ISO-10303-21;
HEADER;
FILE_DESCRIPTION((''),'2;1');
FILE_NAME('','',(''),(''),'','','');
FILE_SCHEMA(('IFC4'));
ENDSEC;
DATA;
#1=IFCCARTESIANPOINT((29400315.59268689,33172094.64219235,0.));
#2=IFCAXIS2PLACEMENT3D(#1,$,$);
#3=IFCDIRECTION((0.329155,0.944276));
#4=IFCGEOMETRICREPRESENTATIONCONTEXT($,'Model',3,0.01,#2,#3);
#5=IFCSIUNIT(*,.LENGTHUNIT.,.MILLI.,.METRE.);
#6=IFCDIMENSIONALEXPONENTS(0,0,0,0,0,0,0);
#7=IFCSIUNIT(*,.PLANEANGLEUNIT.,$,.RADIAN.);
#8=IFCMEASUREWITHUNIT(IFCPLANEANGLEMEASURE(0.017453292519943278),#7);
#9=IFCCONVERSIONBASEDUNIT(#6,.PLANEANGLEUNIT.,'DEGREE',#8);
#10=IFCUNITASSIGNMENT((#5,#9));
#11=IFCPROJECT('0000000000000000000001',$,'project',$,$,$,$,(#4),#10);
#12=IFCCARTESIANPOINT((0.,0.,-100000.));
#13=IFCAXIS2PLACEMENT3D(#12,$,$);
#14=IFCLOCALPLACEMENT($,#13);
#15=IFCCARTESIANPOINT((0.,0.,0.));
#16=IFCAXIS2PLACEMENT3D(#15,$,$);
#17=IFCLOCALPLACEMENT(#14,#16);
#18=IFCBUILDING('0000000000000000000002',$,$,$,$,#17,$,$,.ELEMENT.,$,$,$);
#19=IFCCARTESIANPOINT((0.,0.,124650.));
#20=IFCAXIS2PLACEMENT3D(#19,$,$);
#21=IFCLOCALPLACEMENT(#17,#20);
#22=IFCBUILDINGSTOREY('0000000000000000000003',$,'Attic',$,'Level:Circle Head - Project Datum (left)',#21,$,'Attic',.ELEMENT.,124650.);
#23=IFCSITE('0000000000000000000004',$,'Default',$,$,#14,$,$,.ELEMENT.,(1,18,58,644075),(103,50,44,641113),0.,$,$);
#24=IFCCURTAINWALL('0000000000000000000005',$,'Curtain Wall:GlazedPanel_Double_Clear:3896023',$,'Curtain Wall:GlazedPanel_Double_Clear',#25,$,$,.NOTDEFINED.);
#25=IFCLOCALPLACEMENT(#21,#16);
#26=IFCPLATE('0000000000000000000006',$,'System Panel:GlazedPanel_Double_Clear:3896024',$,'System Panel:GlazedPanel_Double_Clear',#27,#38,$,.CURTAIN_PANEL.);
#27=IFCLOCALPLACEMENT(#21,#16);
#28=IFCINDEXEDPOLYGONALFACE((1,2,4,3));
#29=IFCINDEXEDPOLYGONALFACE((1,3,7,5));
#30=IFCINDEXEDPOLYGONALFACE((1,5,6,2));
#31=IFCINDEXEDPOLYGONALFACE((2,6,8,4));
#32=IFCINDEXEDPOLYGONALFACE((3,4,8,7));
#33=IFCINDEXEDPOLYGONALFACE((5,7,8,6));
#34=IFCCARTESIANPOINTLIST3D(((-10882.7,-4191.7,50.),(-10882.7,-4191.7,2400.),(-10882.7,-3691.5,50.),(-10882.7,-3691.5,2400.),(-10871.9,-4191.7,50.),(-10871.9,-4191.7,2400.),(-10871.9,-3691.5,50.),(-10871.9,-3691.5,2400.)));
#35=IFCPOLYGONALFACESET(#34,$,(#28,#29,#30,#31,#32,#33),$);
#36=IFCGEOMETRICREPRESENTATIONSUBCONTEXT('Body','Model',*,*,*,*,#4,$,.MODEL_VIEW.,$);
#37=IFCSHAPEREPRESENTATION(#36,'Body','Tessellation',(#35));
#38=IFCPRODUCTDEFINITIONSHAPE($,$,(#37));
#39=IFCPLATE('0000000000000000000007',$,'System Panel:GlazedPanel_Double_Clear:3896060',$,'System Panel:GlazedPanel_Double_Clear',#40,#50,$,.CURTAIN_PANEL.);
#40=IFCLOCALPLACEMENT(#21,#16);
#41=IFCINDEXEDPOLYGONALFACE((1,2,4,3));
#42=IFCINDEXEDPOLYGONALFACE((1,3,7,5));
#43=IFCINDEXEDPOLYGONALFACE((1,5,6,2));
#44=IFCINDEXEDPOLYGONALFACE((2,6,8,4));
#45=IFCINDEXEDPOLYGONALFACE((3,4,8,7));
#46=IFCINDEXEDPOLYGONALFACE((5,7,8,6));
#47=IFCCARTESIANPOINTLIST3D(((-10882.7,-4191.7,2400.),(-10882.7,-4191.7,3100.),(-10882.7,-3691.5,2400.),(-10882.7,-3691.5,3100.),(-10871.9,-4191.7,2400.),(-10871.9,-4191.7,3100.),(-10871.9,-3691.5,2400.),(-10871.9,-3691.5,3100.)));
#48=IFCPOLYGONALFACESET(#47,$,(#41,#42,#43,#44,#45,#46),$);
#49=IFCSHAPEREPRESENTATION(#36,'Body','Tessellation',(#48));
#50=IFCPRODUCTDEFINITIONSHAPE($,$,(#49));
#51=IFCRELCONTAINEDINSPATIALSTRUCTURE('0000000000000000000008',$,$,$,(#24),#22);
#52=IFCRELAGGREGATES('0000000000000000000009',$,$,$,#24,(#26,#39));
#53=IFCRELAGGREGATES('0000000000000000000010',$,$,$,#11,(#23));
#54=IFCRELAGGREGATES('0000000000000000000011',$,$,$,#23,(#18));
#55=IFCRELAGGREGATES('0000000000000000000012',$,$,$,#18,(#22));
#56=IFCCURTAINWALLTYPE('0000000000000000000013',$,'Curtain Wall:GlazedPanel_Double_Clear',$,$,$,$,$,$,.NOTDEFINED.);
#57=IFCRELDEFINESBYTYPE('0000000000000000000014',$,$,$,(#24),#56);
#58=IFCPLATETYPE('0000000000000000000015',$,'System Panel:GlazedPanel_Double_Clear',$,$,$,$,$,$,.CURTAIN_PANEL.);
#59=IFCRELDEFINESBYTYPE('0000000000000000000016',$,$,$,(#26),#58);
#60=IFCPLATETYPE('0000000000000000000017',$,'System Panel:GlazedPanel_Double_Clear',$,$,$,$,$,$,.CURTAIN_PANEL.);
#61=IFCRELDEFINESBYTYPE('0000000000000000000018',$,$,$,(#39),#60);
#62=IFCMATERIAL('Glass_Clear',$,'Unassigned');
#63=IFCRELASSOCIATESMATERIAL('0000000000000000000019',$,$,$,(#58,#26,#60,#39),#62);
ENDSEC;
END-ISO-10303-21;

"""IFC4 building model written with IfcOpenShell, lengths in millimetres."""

from ifc_helpers import new_model, entity, si_unit, converted_unit, direction, frame, origin, place, context, subcontext, project, spatial, indexed_curve, outline, extrude, source, transform, mapped, material, type_object, type_shapes, element, aggregate, save


model = new_model("IFC4")

# Units and contexts
model_context = context("Model", 3, precision=0.01, world=frame((29400315.59268689, 33172094.64219235, 0.0)), true_north=direction((0.329155, 0.944276)))
body_context = subcontext(model_context, "Body", "Model", "MODEL_VIEW")
ifc_project = project(units=[si_unit("LENGTHUNIT", "METRE", prefix="MILLI"), converted_unit("PLANEANGLEUNIT", "DEGREE", entity("IfcPlaneAngleMeasure", 0.017453292519943278), si_unit("PLANEANGLEUNIT", "RADIAN"), dimensions=[0, 0, 0, 0, 0, 0, 0])], contexts=[model_context])

# Site, building, storey
site_placement = place(None, frame((0.0, 0.0, -100000.0)))
site = spatial("IfcSite", under=ifc_project, at=site_placement, Name="Default", CompositionType="ELEMENT", RefLatitude=(1, 18, 58, 644075), RefLongitude=(103, 50, 44, 641113), RefElevation=0.0)
building_placement = place(site_placement, origin())
building = spatial("IfcBuilding", under=site, at=building_placement, CompositionType="ELEMENT")
storey_placement = place(building_placement, frame((0.0, 0.0, 124650.0)))
storey = spatial("IfcBuildingStorey", under=building, at=storey_placement, Name="Attic", ObjectType="Level:Circle Head - Project Datum (left)", LongName="Attic", CompositionType="ELEMENT", Elevation=124650.0)

# Shared definitions
curtain_wall_type = type_object("IfcCurtainWallType", Name="Curtain Wall:GlazedPanel_Double_Clear", PredefinedType="NOTDEFINED")

# Curtain wall
curtain_wall_1_placement = place(storey_placement, frame((0.0, 0.0, -124650.0)))
curtain_wall_1 = element("IfcCurtainWall", 1, at=curtain_wall_1_placement, inside=storey, type_object=curtain_wall_type, Name="Curtain Wall:GlazedPanel_Double_Clear:3896023", ObjectType="Curtain Wall:GlazedPanel_Double_Clear", PredefinedType="NOTDEFINED")

# Plates
ifc_material_1 = material(Name="Glass_Clear", Category="Unassigned")
plate_type_1 = type_object("IfcPlateType", Name="System Panel:GlazedPanel_Double_Clear", PredefinedType="CURTAIN_PANEL", material=ifc_material_1)
shared_shape_1 = source(origin(), body_context, "Body", "SweptSolid", [
    extrude(outline(indexed_curve([(-5.4, -250.1), (5.4, -250.1), (5.4, 250.1), (-5.4, 250.1), (-5.4, -250.1)], self_intersect=False)), frame((0.0, -111.0, 0.0), z_axis=(0.0, 0.0, 1.0), x_axis=(0.0, 1.0, 0.0)), (0.0, 0.0, 1.0), 2350.0),
])
type_shapes(plate_type_1, [shared_shape_1])
plate_1_placement = place(curtain_wall_1_placement, frame((-10988.3, -3941.6, 124700.0), z_axis=(0.0, 0.0, 1.0), x_axis=(0.0, 1.0, 0.0)))
plate_1 = element("IfcPlate", 2, at=plate_1_placement, type_object=plate_type_1, material=ifc_material_1, Name="System Panel:GlazedPanel_Double_Clear:3896024", ObjectType="System Panel:GlazedPanel_Double_Clear", PredefinedType="CURTAIN_PANEL", context=body_context, shape_type="MappedRepresentation", body=[
    mapped(shared_shape_1, transform((0.0, 0.0, 0.0), scale=1.0)),
])
plate_type_2 = type_object("IfcPlateType", Name="System Panel:GlazedPanel_Double_Clear", PredefinedType="CURTAIN_PANEL", material=ifc_material_1)
shared_shape_2 = source(origin(), body_context, "Body", "SweptSolid", [
    extrude(outline(indexed_curve([(-5.4, -250.1), (5.4, -250.1), (5.4, 250.1), (-5.4, 250.1), (-5.4, -250.1)], self_intersect=False)), frame((0.0, -111.0, 0.0), z_axis=(0.0, 0.0, 1.0), x_axis=(0.0, 1.0, 0.0)), (0.0, 0.0, 1.0), 700.0),
])
type_shapes(plate_type_2, [shared_shape_2])
plate_2_placement = place(curtain_wall_1_placement, frame((-10988.3, -3941.6, 127050.0), z_axis=(0.0, 0.0, 1.0), x_axis=(0.0, 1.0, 0.0)))
plate_2 = element("IfcPlate", 3, at=plate_2_placement, type_object=plate_type_2, material=ifc_material_1, Name="System Panel:GlazedPanel_Double_Clear:3896060", ObjectType="System Panel:GlazedPanel_Double_Clear", PredefinedType="CURTAIN_PANEL", context=body_context, shape_type="MappedRepresentation", body=[
    mapped(shared_shape_2, transform((0.0, 0.0, 0.0), scale=1.0)),
])
aggregate(curtain_wall_1, [plate_1, plate_2])

save(model, "model.ifc")
